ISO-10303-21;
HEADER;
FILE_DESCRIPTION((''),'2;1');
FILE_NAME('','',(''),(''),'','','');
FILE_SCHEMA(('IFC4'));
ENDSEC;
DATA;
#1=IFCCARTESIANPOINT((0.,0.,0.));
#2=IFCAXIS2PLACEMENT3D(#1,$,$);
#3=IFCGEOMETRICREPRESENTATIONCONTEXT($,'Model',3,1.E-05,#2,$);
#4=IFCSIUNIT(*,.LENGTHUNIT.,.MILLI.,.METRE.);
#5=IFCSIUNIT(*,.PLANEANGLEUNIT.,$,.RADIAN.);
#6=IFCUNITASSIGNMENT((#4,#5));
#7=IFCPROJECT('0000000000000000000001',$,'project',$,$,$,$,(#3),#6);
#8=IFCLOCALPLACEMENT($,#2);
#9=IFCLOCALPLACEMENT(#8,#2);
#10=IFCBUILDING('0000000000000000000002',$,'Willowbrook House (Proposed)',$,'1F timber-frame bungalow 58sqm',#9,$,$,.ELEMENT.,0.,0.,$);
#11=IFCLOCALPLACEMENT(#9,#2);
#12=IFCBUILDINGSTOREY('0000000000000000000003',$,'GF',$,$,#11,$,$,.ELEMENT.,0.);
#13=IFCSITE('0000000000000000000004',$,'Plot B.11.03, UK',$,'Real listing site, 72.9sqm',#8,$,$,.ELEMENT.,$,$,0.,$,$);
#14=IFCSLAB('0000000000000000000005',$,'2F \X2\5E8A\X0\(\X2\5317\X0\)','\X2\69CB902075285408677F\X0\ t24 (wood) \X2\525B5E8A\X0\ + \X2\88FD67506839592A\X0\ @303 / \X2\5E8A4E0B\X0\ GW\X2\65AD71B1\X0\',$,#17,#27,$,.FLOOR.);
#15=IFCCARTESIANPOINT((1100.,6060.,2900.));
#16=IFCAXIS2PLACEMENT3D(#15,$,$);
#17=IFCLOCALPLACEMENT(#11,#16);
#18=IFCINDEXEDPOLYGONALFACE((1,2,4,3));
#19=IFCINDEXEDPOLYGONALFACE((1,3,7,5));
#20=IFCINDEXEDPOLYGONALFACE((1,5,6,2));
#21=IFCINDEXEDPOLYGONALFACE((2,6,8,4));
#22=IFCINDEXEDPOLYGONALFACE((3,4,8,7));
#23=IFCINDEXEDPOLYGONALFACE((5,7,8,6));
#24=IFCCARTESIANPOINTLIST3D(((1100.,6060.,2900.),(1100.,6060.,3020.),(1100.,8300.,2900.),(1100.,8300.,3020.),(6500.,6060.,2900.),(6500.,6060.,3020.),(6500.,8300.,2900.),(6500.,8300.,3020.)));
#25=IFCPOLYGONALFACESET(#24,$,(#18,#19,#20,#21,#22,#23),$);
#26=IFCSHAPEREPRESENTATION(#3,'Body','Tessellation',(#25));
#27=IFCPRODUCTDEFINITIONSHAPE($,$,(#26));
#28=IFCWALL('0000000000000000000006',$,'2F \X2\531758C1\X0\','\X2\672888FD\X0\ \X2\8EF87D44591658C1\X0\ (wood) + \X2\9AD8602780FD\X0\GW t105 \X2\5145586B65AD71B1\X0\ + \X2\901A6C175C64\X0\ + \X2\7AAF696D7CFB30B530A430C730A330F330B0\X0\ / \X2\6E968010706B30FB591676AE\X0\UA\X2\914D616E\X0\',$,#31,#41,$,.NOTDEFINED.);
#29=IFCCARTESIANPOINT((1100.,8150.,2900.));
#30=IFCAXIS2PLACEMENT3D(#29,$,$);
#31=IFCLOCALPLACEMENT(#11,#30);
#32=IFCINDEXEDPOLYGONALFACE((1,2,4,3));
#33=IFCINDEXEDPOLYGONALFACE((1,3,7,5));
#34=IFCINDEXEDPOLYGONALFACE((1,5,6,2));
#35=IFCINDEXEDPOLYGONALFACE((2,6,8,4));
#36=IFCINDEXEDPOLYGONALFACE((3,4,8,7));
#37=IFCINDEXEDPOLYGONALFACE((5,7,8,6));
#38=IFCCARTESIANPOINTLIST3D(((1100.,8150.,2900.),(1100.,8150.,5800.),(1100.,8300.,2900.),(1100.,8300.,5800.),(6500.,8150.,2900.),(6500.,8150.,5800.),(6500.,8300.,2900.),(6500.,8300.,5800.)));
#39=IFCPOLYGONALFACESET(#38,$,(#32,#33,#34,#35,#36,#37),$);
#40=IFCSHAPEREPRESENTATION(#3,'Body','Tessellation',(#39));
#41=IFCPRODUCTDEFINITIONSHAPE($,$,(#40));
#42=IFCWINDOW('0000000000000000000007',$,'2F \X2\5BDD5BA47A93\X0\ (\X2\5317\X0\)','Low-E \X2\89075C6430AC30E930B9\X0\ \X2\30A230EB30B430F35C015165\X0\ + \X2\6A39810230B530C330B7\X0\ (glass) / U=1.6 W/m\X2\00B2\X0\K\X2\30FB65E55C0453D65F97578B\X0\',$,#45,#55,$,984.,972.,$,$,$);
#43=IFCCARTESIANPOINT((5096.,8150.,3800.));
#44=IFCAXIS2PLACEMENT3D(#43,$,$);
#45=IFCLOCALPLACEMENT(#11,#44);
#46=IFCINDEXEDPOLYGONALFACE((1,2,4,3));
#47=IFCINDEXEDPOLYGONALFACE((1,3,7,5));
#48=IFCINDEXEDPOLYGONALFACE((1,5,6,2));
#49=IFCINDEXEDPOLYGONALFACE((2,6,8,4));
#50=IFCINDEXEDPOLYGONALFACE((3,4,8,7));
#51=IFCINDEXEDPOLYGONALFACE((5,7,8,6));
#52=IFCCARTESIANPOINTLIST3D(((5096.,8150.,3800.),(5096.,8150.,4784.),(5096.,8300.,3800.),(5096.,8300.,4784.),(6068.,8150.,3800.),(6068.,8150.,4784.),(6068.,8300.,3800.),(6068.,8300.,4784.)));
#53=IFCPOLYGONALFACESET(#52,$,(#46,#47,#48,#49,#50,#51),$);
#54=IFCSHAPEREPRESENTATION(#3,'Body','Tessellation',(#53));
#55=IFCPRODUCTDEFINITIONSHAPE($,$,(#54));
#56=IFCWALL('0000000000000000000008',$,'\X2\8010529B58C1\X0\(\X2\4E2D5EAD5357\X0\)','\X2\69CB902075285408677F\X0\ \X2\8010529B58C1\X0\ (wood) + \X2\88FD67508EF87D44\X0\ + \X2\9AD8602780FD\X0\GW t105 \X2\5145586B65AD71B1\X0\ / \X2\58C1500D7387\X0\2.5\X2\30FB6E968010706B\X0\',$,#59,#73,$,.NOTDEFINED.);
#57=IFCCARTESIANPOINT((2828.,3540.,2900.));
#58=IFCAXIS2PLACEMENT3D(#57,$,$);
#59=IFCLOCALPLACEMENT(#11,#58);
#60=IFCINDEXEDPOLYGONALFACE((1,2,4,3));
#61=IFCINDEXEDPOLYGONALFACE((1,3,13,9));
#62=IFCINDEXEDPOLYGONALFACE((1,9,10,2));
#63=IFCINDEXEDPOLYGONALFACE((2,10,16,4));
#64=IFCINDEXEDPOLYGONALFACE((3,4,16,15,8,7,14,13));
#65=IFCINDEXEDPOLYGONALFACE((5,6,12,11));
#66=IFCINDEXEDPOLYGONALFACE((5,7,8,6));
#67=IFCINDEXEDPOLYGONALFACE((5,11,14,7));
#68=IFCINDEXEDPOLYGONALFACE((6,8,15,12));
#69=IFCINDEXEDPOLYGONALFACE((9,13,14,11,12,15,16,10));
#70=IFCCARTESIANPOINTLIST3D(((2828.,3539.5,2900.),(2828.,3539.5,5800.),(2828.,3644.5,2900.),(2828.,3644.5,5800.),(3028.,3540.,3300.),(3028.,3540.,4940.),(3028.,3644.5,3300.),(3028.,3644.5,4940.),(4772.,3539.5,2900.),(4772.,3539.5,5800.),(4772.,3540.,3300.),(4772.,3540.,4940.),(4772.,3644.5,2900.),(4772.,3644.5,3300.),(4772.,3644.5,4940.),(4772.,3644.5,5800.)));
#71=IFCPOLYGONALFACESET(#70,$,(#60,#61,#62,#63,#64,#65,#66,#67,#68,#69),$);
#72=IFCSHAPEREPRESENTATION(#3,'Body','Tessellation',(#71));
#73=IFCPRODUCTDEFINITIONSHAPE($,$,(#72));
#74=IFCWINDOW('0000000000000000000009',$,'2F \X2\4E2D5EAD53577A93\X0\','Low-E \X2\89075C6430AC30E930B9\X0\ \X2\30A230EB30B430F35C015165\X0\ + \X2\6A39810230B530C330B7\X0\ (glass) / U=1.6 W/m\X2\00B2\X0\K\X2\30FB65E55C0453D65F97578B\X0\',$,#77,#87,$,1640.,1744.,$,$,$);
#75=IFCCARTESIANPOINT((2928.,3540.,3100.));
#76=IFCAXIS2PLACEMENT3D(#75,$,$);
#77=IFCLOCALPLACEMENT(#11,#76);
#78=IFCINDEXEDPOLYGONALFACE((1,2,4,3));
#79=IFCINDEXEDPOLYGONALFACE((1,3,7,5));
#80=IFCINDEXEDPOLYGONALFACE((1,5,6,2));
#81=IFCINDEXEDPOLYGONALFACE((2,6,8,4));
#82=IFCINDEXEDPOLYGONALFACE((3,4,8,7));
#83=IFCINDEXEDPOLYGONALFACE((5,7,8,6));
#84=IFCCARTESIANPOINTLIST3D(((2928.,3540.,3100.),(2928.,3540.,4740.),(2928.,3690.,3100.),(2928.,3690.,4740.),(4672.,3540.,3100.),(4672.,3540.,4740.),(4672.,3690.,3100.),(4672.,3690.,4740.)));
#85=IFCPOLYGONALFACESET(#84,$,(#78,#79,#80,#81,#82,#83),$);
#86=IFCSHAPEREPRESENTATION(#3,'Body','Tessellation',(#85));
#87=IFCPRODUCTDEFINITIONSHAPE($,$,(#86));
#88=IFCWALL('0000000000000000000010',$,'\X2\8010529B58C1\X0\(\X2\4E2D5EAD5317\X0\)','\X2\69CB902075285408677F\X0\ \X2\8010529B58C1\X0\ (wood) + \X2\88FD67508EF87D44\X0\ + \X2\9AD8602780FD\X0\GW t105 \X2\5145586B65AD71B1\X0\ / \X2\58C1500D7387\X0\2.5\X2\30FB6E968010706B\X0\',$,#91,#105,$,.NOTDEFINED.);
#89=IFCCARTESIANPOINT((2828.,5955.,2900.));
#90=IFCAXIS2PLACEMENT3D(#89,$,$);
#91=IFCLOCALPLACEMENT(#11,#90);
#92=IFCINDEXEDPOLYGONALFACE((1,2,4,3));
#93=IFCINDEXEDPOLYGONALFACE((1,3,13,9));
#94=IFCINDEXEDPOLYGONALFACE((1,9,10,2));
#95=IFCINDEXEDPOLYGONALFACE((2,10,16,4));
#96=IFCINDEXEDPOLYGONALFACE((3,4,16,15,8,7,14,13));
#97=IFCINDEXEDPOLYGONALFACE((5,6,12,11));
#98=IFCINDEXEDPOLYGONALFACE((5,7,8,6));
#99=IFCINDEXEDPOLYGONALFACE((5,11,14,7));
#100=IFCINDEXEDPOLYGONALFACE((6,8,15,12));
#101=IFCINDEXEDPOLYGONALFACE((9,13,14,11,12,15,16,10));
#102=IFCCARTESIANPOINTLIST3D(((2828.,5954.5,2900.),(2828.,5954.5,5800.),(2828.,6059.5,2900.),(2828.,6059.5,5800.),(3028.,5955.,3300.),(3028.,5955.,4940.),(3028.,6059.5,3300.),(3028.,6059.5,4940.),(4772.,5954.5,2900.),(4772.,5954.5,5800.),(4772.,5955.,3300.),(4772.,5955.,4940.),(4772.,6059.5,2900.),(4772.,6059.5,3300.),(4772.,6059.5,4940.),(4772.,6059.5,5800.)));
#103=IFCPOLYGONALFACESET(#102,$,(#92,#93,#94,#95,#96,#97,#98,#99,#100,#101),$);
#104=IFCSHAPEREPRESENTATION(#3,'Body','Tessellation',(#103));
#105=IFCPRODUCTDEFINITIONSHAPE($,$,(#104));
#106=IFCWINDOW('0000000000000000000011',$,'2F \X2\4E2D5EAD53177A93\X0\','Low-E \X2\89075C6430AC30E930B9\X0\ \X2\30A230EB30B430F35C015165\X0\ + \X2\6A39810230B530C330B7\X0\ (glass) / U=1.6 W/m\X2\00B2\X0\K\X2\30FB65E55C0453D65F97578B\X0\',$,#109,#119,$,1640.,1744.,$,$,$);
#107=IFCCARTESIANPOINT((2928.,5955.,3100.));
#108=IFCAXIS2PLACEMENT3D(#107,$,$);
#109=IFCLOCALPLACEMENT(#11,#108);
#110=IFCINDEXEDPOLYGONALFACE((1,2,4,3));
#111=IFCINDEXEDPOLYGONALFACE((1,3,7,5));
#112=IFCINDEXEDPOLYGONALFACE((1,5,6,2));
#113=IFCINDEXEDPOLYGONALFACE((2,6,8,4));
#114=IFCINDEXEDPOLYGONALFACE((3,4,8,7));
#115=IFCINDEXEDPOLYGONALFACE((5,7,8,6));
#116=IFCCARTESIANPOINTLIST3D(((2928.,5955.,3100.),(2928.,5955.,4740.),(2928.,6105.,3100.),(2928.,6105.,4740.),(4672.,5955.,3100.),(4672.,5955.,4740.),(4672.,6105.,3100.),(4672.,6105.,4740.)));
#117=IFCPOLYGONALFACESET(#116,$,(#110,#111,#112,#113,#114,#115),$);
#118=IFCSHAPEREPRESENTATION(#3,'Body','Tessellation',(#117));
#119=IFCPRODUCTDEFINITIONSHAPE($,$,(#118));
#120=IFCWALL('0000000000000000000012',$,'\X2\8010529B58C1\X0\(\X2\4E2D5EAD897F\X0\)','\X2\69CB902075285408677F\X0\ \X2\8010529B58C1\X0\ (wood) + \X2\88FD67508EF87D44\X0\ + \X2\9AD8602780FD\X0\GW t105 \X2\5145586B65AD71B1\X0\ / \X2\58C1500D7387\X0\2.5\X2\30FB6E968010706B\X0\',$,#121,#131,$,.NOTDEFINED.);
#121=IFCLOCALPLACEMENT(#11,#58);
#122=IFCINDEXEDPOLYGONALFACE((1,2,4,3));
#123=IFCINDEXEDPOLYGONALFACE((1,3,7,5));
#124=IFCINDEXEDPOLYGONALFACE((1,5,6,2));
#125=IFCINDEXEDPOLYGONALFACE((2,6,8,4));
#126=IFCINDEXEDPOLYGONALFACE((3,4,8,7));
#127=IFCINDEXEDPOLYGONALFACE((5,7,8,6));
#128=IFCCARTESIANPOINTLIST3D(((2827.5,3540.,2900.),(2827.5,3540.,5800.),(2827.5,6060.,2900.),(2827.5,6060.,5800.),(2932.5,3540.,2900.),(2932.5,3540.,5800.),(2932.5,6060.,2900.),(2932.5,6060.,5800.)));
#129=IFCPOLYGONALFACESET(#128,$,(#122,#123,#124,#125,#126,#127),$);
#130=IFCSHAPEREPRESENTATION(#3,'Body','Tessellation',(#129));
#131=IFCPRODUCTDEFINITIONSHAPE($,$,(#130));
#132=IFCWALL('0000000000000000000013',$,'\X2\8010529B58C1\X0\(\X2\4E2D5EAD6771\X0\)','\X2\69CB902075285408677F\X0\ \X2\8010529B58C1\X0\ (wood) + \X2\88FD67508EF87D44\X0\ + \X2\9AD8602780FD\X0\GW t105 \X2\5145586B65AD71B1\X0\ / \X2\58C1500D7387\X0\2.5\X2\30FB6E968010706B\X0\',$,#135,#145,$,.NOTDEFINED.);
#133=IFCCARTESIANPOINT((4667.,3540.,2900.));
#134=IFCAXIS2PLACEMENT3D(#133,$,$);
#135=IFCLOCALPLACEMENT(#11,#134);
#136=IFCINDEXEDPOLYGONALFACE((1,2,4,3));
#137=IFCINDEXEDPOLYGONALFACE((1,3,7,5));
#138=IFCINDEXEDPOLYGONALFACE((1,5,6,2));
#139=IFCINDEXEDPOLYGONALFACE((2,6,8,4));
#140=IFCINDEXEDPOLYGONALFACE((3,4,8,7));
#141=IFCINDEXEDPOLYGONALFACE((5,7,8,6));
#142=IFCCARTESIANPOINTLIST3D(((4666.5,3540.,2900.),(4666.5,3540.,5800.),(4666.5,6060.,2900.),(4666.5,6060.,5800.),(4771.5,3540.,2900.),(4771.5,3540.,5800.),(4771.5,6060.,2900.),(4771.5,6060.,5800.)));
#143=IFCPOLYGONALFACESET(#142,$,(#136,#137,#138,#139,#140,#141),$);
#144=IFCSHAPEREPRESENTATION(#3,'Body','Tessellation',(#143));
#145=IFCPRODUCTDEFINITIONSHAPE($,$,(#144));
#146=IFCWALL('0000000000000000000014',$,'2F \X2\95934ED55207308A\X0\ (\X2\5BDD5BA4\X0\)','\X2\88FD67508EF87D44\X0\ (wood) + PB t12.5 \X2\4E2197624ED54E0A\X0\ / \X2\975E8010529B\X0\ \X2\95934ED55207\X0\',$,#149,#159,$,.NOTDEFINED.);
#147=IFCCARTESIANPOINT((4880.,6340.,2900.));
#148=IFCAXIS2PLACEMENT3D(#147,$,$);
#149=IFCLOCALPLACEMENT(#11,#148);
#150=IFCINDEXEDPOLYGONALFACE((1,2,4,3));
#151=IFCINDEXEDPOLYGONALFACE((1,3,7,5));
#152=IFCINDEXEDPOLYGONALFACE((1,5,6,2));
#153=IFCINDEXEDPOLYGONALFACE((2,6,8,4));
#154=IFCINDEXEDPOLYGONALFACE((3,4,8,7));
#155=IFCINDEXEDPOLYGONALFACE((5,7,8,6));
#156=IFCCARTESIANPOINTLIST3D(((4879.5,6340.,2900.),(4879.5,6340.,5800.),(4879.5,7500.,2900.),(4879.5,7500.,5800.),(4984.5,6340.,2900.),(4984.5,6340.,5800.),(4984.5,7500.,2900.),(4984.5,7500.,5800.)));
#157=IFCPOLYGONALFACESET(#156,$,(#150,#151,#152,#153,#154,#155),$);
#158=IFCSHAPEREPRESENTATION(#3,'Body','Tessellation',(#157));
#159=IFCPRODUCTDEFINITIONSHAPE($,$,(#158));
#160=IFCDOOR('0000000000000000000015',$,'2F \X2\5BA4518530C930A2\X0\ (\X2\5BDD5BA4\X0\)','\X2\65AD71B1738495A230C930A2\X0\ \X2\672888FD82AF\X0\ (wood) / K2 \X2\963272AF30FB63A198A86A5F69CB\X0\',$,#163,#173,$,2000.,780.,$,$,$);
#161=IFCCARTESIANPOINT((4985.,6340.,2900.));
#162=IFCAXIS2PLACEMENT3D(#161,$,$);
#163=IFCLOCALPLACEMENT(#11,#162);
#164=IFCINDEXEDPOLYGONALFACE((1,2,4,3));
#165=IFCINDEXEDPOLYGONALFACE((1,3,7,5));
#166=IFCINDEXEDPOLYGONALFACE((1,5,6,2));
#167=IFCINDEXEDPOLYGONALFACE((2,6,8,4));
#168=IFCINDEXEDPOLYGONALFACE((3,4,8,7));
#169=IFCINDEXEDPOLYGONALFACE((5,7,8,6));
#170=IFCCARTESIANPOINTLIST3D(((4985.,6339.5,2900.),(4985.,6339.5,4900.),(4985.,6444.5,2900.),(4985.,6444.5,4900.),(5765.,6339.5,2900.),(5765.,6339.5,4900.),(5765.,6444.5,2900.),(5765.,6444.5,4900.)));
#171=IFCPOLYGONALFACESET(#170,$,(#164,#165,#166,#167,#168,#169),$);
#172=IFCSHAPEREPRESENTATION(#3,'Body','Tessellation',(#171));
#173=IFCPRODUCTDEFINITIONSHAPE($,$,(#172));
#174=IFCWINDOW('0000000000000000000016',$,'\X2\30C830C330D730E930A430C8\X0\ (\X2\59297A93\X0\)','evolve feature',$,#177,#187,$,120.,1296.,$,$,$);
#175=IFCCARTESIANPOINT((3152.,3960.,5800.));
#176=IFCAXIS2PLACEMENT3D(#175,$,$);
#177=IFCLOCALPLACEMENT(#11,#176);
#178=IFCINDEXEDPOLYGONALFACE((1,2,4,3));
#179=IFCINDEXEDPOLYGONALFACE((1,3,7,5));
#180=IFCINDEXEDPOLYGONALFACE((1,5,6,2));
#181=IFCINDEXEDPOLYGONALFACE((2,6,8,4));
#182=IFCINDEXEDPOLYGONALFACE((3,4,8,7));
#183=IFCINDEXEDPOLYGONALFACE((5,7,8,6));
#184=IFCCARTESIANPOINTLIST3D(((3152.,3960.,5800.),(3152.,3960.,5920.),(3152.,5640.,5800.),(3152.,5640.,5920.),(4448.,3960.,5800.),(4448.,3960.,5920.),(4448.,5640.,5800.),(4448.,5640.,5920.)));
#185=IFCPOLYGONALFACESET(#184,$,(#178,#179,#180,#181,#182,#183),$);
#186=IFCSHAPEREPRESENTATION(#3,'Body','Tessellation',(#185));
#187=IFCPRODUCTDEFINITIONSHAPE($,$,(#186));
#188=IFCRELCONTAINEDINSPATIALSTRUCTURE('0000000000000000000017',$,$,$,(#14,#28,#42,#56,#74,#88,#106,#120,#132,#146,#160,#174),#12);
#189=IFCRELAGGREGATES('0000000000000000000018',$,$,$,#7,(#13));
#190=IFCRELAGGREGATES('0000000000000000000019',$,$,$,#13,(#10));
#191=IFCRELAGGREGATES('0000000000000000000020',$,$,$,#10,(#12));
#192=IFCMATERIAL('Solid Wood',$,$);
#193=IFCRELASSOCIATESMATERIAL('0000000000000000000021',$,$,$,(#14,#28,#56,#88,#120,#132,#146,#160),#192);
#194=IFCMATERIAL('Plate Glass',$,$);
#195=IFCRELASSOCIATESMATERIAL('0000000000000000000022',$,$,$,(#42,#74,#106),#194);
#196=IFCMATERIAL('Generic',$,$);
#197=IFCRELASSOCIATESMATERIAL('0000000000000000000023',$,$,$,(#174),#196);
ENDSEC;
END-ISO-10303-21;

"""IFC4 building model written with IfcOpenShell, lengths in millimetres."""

from ifc_helpers import new_model, si_unit, frame, frame_2d, origin, place, context, project, spatial, rectangle, extrude, material, element, fill, save


model = new_model("IFC4")

# Units and contexts
model_context = context("Model", 3, precision=1e-05, world=origin())
ifc_project = project(units=[si_unit("LENGTHUNIT", "METRE", prefix="MILLI"), si_unit("PLANEANGLEUNIT", "RADIAN")], contexts=[model_context])

# Site, building, storey
site_placement = place(None, origin())
site = spatial("IfcSite", under=ifc_project, at=site_placement, Name="Plot B.11.03, UK", ObjectType="Real listing site, 72.9sqm", CompositionType="ELEMENT", RefElevation=0.0)
building_placement = place(site_placement, origin())
building = spatial("IfcBuilding", under=site, at=building_placement, Name="Willowbrook House (Proposed)", ObjectType="1F timber-frame bungalow 58sqm", CompositionType="ELEMENT", ElevationOfRefHeight=0.0, ElevationOfTerrain=0.0)
storey_placement = place(building_placement, origin())
storey = spatial("IfcBuildingStorey", under=building, at=storey_placement, Name="GF", CompositionType="ELEMENT", Elevation=0.0)

# Slab
ifc_material_1 = material(Name="Solid Wood")
slab_placement = place(storey_placement, frame((1100.0, 6060.0, 2900.0)))
element("IfcSlab", 1, at=slab_placement, inside=storey, material=ifc_material_1, Name="2F 床(北)", Description="構造用合板 t24 (wood) 剛床 + 製材根太 @303 / 床下 GW断熱", PredefinedType="FLOOR", context=model_context, shape_type="SweptSolid", body=[
    extrude(rectangle(XDim=5400.0, YDim=2240.0, at=frame_2d((2700.0, 1120.0))), frame((1100.0, 6060.0, 2900.0)), (0.0, 0.0, 1.0), 120.0),
])

# Walls, openings, windows
wall_1_placement = place(storey_placement, frame((1100.0, 8150.0, 2900.0)))
wall_1 = element("IfcWall", 2, at=wall_1_placement, inside=storey, material=ifc_material_1, Name="2F 北壁", Description="木製 軸組外壁 (wood) + 高性能GW t105 充填断熱 + 通気層 + 窯業系サイディング / 準耐火・外皮UA配慮", PredefinedType="NOTDEFINED", context=model_context, shape_type="SweptSolid", body=[
    extrude(rectangle(XDim=5400.0, YDim=150.0, at=frame_2d((2700.0, 75.0))), frame((1100.0, 8150.0, 2900.0)), (0.0, 0.0, 1.0), 2900.0),
])
opening_1_placement = place(storey_placement, frame((5096.0, 8150.0, 3800.0)))
opening_1 = element("IfcOpeningElement", 3, at=opening_1_placement, cuts=wall_1, PredefinedType="NOTDEFINED", context=model_context, shape_type="SweptSolid", body=[
    extrude(rectangle(XDim=972.0, YDim=150.0, at=frame_2d((486.0, 75.0))), frame((5096.0, 8150.0, 3800.0)), (0.0, 0.0, 1.0), 984.0),
])
ifc_material_2 = material(Name="Plate Glass")
window_1_placement = place(storey_placement, frame((5096.0, 8150.0, 3800.0)))
window_1 = element("IfcWindow", 4, at=window_1_placement, inside=storey, material=ifc_material_2, Name="2F 寝室窓 (北)", Description="Low-E 複層ガラス アルゴン封入 + 樹脂サッシ (glass) / U=1.6 W/m²K・日射取得型", OverallHeight=984.0, OverallWidth=972.0, context=model_context, shape_type="SweptSolid", body=[
    extrude(rectangle(XDim=972.0, YDim=150.0, at=frame_2d((486.0, 75.0))), frame((5096.0, 8150.0, 3800.0)), (0.0, 0.0, 1.0), 984.0),
])
fill(opening_1, window_1)
wall_2_placement = place(storey_placement, frame((2828.0, 3540.0, 2900.0)))
wall_2 = element("IfcWall", 5, at=wall_2_placement, inside=storey, material=ifc_material_1, Name="耐力壁(中庭南)", Description="構造用合板 耐力壁 (wood) + 製材軸組 + 高性能GW t105 充填断熱 / 壁倍率2.5・準耐火", PredefinedType="NOTDEFINED", context=model_context, shape_type="SweptSolid", body=[
    extrude(rectangle(XDim=1944.0, YDim=105.0, at=frame_2d((972.0, 52.0))), frame((2828.0, 3540.0, 2900.0)), (0.0, 0.0, 1.0), 2900.0),
])
opening_2_placement = place(storey_placement, frame((2928.0, 3540.0, 3100.0)))
opening_2 = element("IfcOpeningElement", 6, at=opening_2_placement, cuts=wall_2, PredefinedType="NOTDEFINED", context=model_context, shape_type="SweptSolid", body=[
    extrude(rectangle(XDim=1744.0, YDim=150.0, at=frame_2d((872.0, 75.0))), frame((2928.0, 3540.0, 3100.0)), (0.0, 0.0, 1.0), 1640.0),
])
window_2_placement = place(storey_placement, frame((2928.0, 3540.0, 3100.0)))
window_2 = element("IfcWindow", 7, at=window_2_placement, inside=storey, material=ifc_material_2, Name="2F 中庭南窓", Description="Low-E 複層ガラス アルゴン封入 + 樹脂サッシ (glass) / U=1.6 W/m²K・日射取得型", OverallHeight=1640.0, OverallWidth=1744.0, context=model_context, shape_type="SweptSolid", body=[
    extrude(rectangle(XDim=1744.0, YDim=150.0, at=frame_2d((872.0, 75.0))), frame((2928.0, 3540.0, 3100.0)), (0.0, 0.0, 1.0), 1640.0),
])
fill(opening_2, window_2)
wall_3_placement = place(storey_placement, frame((2828.0, 5955.0, 2900.0)))
wall_3 = element("IfcWall", 8, at=wall_3_placement, inside=storey, material=ifc_material_1, Name="耐力壁(中庭北)", Description="構造用合板 耐力壁 (wood) + 製材軸組 + 高性能GW t105 充填断熱 / 壁倍率2.5・準耐火", PredefinedType="NOTDEFINED", context=model_context, shape_type="SweptSolid", body=[
    extrude(rectangle(XDim=1944.0, YDim=105.0, at=frame_2d((972.0, 52.0))), frame((2828.0, 5955.0, 2900.0)), (0.0, 0.0, 1.0), 2900.0),
])
opening_3_placement = place(storey_placement, frame((2928.0, 5955.0, 3100.0)))
opening_3 = element("IfcOpeningElement", 9, at=opening_3_placement, cuts=wall_3, PredefinedType="NOTDEFINED", context=model_context, shape_type="SweptSolid", body=[
    extrude(rectangle(XDim=1744.0, YDim=150.0, at=frame_2d((872.0, 75.0))), frame((2928.0, 5955.0, 3100.0)), (0.0, 0.0, 1.0), 1640.0),
])
window_3_placement = place(storey_placement, frame((2928.0, 5955.0, 3100.0)))
window_3 = element("IfcWindow", 10, at=window_3_placement, inside=storey, material=ifc_material_2, Name="2F 中庭北窓", Description="Low-E 複層ガラス アルゴン封入 + 樹脂サッシ (glass) / U=1.6 W/m²K・日射取得型", OverallHeight=1640.0, OverallWidth=1744.0, context=model_context, shape_type="SweptSolid", body=[
    extrude(rectangle(XDim=1744.0, YDim=150.0, at=frame_2d((872.0, 75.0))), frame((2928.0, 5955.0, 3100.0)), (0.0, 0.0, 1.0), 1640.0),
])
fill(opening_3, window_3)

# Walls
wall_4_placement = place(storey_placement, frame((2828.0, 3540.0, 2900.0)))
element("IfcWall", 11, at=wall_4_placement, inside=storey, material=ifc_material_1, Name="耐力壁(中庭西)", Description="構造用合板 耐力壁 (wood) + 製材軸組 + 高性能GW t105 充填断熱 / 壁倍率2.5・準耐火", PredefinedType="NOTDEFINED", context=model_context, shape_type="SweptSolid", body=[
    extrude(rectangle(XDim=105.0, YDim=2520.0, at=frame_2d((52.0, 1260.0))), frame((2828.0, 3540.0, 2900.0)), (0.0, 0.0, 1.0), 2900.0),
])
wall_5_placement = place(storey_placement, frame((4667.0, 3540.0, 2900.0)))
element("IfcWall", 12, at=wall_5_placement, inside=storey, material=ifc_material_1, Name="耐力壁(中庭東)", Description="構造用合板 耐力壁 (wood) + 製材軸組 + 高性能GW t105 充填断熱 / 壁倍率2.5・準耐火", PredefinedType="NOTDEFINED", context=model_context, shape_type="SweptSolid", body=[
    extrude(rectangle(XDim=105.0, YDim=2520.0, at=frame_2d((52.0, 1260.0))), frame((4667.0, 3540.0, 2900.0)), (0.0, 0.0, 1.0), 2900.0),
])
wall_6_placement = place(storey_placement, frame((4880.0, 6340.0, 2900.0)))
element("IfcWall", 13, at=wall_6_placement, inside=storey, material=ifc_material_1, Name="2F 間仕切り (寝室)", Description="製材軸組 (wood) + PB t12.5 両面仕上 / 非耐力 間仕切", PredefinedType="NOTDEFINED", context=model_context, shape_type="SweptSolid", body=[
    extrude(rectangle(XDim=105.0, YDim=1160.0, at=frame_2d((52.0, 580.0))), frame((4880.0, 6340.0, 2900.0)), (0.0, 0.0, 1.0), 2900.0),
])

# Door
door_placement = place(storey_placement, frame((4985.0, 6340.0, 2900.0)))
element("IfcDoor", 14, at=door_placement, inside=storey, material=ifc_material_1, Name="2F 室内ドア (寝室)", Description="断熱玄関ドア 木製芯 (wood) / K2 防犯・採風機構", OverallHeight=2000.0, OverallWidth=780.0, context=model_context, shape_type="SweptSolid", body=[
    extrude(rectangle(XDim=780.0, YDim=105.0, at=frame_2d((390.0, 52.0))), frame((4985.0, 6340.0, 2900.0)), (0.0, 0.0, 1.0), 2000.0),
])

# Window
ifc_material_3 = material(Name="Generic")
window_4_placement = place(storey_placement, frame((3152.0, 3960.0, 5800.0)))
element("IfcWindow", 15, at=window_4_placement, inside=storey, material=ifc_material_3, Name="トップライト (天窓)", Description="evolve feature", OverallHeight=120.0, OverallWidth=1296.0, context=model_context, shape_type="SweptSolid", body=[
    extrude(rectangle(XDim=1296.0, YDim=1680.0, at=frame_2d((648.0, 840.0))), frame((3152.0, 3960.0, 5800.0)), (0.0, 0.0, 1.0), 120.0),
])

save(model, "model.ifc")
